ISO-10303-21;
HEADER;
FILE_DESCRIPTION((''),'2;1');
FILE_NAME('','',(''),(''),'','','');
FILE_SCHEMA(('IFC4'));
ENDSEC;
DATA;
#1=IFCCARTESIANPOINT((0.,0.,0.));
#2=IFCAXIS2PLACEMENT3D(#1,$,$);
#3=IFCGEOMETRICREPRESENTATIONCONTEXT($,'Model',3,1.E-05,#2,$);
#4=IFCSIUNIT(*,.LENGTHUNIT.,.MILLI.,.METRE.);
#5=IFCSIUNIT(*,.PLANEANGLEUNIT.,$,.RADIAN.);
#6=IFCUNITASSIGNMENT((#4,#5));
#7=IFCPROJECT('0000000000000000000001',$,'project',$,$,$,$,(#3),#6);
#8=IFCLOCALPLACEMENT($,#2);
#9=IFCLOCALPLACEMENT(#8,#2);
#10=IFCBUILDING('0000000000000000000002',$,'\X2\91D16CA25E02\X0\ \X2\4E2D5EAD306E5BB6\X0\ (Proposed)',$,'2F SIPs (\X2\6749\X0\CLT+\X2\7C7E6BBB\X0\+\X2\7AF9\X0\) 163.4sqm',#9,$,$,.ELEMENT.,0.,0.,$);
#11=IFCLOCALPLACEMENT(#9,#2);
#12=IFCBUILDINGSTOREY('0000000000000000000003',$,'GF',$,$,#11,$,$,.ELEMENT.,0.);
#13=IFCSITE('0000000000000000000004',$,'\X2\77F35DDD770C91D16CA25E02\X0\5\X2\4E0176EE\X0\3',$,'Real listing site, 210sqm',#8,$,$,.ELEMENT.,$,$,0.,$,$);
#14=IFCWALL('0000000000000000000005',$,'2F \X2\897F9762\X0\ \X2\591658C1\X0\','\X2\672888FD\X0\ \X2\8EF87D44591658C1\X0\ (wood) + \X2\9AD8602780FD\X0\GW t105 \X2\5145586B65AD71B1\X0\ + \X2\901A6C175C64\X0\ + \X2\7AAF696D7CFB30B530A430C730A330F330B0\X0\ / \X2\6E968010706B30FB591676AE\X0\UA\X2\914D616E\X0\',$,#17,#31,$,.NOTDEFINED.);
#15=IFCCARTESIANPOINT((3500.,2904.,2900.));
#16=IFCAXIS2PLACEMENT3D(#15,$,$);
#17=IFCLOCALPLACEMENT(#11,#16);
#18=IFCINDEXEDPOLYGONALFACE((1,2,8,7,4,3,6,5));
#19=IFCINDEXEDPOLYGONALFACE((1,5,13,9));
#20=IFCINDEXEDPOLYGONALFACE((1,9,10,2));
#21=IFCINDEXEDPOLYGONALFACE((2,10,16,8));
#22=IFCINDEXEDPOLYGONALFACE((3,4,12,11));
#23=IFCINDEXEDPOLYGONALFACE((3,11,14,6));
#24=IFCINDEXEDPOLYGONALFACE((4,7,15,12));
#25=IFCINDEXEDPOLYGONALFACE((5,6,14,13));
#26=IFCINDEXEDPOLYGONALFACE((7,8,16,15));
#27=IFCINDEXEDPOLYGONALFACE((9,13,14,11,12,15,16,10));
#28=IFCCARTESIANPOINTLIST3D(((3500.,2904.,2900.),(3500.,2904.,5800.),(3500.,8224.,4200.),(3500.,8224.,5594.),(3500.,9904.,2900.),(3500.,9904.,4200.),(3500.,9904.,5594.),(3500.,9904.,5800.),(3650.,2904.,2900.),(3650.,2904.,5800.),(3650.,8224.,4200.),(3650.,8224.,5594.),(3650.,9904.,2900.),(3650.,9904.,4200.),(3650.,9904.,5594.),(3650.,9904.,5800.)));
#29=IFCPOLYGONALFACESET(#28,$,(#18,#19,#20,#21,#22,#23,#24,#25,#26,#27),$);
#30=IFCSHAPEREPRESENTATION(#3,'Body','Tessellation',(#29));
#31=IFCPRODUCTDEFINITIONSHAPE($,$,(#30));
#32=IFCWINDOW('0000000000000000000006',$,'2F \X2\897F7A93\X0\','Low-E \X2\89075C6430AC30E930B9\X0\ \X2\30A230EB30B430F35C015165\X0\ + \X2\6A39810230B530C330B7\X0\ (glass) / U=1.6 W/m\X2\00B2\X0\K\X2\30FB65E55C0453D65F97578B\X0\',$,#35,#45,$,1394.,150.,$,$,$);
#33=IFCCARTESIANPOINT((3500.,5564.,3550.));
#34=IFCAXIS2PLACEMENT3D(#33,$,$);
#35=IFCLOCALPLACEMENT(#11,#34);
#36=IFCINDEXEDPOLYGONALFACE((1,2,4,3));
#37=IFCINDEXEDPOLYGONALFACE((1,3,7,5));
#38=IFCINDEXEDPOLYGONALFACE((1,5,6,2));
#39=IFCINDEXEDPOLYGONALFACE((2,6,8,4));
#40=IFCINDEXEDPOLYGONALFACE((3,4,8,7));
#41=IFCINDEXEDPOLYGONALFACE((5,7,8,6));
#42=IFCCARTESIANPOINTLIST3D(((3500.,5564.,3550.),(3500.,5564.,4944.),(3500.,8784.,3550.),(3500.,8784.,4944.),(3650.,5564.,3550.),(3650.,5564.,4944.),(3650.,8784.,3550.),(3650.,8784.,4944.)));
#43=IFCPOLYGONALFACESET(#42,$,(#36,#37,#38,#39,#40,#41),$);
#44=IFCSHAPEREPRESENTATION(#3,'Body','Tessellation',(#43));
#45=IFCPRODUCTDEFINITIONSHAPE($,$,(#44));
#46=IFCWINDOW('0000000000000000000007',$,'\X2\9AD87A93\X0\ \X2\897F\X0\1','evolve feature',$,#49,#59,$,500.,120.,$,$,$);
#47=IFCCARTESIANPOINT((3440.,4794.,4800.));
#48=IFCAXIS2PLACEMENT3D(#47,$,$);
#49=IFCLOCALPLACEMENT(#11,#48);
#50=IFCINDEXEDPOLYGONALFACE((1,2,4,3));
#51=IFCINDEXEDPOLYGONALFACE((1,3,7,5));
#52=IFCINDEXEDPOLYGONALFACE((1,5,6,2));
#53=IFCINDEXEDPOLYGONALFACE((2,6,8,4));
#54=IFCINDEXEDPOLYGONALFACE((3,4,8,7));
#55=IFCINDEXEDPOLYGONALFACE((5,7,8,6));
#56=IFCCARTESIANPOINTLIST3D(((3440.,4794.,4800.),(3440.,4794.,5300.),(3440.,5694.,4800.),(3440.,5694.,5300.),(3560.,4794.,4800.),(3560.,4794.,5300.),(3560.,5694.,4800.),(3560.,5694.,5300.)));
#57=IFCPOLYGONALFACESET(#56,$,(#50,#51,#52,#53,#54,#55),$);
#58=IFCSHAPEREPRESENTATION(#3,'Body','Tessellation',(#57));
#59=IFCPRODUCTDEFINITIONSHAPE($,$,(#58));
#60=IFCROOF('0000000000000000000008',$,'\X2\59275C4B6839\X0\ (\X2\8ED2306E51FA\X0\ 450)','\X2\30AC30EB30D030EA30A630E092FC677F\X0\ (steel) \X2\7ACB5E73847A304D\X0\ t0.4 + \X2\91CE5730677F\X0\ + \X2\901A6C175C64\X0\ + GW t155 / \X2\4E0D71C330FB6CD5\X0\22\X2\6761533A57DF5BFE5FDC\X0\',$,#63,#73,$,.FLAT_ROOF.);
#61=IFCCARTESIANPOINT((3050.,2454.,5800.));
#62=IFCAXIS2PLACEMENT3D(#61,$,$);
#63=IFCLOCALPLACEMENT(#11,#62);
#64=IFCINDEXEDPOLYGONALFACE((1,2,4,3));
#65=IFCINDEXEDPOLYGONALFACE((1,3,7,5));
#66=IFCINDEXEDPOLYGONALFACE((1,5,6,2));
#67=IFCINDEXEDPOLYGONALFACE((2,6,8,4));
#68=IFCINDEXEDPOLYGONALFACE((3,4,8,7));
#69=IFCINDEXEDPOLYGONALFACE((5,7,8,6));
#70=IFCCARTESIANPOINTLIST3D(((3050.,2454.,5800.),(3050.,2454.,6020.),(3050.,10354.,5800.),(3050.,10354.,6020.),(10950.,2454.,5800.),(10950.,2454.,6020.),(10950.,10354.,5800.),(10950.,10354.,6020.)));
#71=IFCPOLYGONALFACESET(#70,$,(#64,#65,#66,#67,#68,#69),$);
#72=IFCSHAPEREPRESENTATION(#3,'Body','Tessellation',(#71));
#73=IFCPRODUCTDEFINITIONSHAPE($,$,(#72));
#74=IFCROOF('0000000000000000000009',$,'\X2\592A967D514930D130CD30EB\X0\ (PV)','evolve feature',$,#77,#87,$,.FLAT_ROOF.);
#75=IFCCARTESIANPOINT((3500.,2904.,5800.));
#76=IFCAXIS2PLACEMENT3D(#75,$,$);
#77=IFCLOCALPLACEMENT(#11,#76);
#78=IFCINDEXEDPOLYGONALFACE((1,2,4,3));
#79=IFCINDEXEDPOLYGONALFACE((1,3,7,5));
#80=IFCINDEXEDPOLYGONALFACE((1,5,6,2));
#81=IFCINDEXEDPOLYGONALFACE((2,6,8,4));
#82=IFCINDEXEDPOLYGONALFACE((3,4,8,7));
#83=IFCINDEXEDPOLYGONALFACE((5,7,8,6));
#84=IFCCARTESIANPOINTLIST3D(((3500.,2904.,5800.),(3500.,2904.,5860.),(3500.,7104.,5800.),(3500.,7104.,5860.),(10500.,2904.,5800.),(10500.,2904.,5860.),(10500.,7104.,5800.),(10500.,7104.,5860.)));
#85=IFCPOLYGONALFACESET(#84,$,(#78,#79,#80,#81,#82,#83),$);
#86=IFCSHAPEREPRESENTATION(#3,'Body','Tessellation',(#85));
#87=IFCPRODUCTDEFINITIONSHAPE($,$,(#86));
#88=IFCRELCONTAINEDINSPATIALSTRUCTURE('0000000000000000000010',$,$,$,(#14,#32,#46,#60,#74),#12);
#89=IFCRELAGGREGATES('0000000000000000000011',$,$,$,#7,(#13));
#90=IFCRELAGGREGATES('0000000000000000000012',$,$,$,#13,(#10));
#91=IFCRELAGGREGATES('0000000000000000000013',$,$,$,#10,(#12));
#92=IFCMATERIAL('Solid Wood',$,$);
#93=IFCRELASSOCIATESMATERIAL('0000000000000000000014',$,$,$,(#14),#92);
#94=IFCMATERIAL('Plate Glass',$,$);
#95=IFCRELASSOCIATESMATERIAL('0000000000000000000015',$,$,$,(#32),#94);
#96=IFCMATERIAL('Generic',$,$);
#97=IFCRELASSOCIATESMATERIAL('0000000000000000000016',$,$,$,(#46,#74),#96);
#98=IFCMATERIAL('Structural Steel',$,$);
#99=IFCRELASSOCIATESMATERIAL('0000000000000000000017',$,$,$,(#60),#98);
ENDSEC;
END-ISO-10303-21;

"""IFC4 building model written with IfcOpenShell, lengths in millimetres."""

from ifc_helpers import new_model, si_unit, frame, frame_2d, origin, place, context, project, spatial, rectangle, extrude, material, element, fill, save


model = new_model("IFC4")

# Units and contexts
model_context = context("Model", 3, precision=1e-05, world=origin())
ifc_project = project(units=[si_unit("LENGTHUNIT", "METRE", prefix="MILLI"), si_unit("PLANEANGLEUNIT", "RADIAN")], contexts=[model_context])

# Site, building, storey
site_placement = place(None, origin())
site = spatial("IfcSite", under=ifc_project, at=site_placement, Name="石川県金沢市5丁目3", ObjectType="Real listing site, 210sqm", CompositionType="ELEMENT", RefElevation=0.0)
building_placement = place(site_placement, origin())
building = spatial("IfcBuilding", under=site, at=building_placement, Name="金沢市 中庭の家 (Proposed)", ObjectType="2F SIPs (杉CLT+籾殻+竹) 163.4sqm", CompositionType="ELEMENT", ElevationOfRefHeight=0.0, ElevationOfTerrain=0.0)
storey_placement = place(building_placement, origin())
storey = spatial("IfcBuildingStorey", under=building, at=storey_placement, Name="GF", CompositionType="ELEMENT", Elevation=0.0)

# Shared definitions
ifc_material_1 = material(Name="Solid Wood")
ifc_material_2 = material(Name="Generic")

# Shared definitions
ifc_material_3 = material(Name="Plate Glass")

# Wall, openings, windows
wall_1_placement = place(storey_placement, frame((3500.0, 2904.0, 2900.0)))
wall_1 = element("IfcWall", 1, at=wall_1_placement, inside=storey, material=ifc_material_1, Name="2F 西面 外壁", Description="木製 軸組外壁 (wood) + 高性能GW t105 充填断熱 + 通気層 + 窯業系サイディング / 準耐火・外皮UA配慮", PredefinedType="NOTDEFINED", context=model_context, shape_type="SweptSolid", body=[
    extrude(rectangle(XDim=150.0, YDim=7000.0, at=frame_2d((75.0, 3500.0))), frame((3500.0, 2904.0, 2900.0)), (0.0, 0.0, 1.0), 2900.0),
])
opening_1_placement = place(storey_placement, frame((3500.0, 5564.0, 3550.0)))
opening_1 = element("IfcOpeningElement", 2, at=opening_1_placement, cuts=wall_1, PredefinedType="NOTDEFINED", context=model_context, shape_type="SweptSolid", body=[
    extrude(rectangle(XDim=150.0, YDim=3220.0, at=frame_2d((75.0, 1610.0))), frame((3500.0, 5564.0, 3550.0)), (0.0, 0.0, 1.0), 1394.0),
])
opening_2_placement = place(storey_placement, frame((3440.0, 4794.0, 4800.0)))
opening_2 = element("IfcOpeningElement", 3, at=opening_2_placement, cuts=wall_1, PredefinedType="NOTDEFINED", context=model_context, shape_type="SweptSolid", body=[
    extrude(rectangle(XDim=120.0, YDim=900.0, at=frame_2d((60.0, 450.0))), frame((3440.0, 4794.0, 4800.0)), (0.0, 0.0, 1.0), 500.0),
])
window_1_placement = place(storey_placement, frame((3500.0, 5564.0, 3550.0)))
window_1 = element("IfcWindow", 4, at=window_1_placement, inside=storey, material=ifc_material_3, Name="2F 西窓", Description="Low-E 複層ガラス アルゴン封入 + 樹脂サッシ (glass) / U=1.6 W/m²K・日射取得型", OverallHeight=1394.0, OverallWidth=150.0, context=model_context, shape_type="SweptSolid", body=[
    extrude(rectangle(XDim=150.0, YDim=3220.0, at=frame_2d((75.0, 1610.0))), frame((3500.0, 5564.0, 3550.0)), (0.0, 0.0, 1.0), 1394.0),
])
fill(opening_1, window_1)
window_2_placement = place(storey_placement, frame((3440.0, 4794.0, 4800.0)))
window_2 = element("IfcWindow", 5, at=window_2_placement, inside=storey, material=ifc_material_2, Name="高窓 西1", Description="evolve feature", OverallHeight=500.0, OverallWidth=120.0, context=model_context, shape_type="SweptSolid", body=[
    extrude(rectangle(XDim=120.0, YDim=900.0, at=frame_2d((60.0, 450.0))), frame((3440.0, 4794.0, 4800.0)), (0.0, 0.0, 1.0), 500.0),
])
fill(opening_2, window_2)

# Roofs
ifc_material_4 = material(Name="Structural Steel")
roof_1_placement = place(storey_placement, frame((3050.0, 2454.0, 5800.0)))
element("IfcRoof", 6, at=roof_1_placement, inside=storey, material=ifc_material_4, Name="大屋根 (軒の出 450)", Description="ガルバリウム鋼板 (steel) 立平葺き t0.4 + 野地板 + 通気層 + GW t155 / 不燃・法22条区域対応", PredefinedType="FLAT_ROOF", context=model_context, shape_type="SweptSolid", body=[
    extrude(rectangle(XDim=7900.0, YDim=7900.0, at=frame_2d((3950.0, 3950.0))), frame((3050.0, 2454.0, 5800.0)), (0.0, 0.0, 1.0), 220.0),
])
roof_2_placement = place(storey_placement, frame((3500.0, 2904.0, 5800.0)))
element("IfcRoof", 7, at=roof_2_placement, inside=storey, material=ifc_material_2, Name="太陽光パネル (PV)", Description="evolve feature", PredefinedType="FLAT_ROOF", context=model_context, shape_type="SweptSolid", body=[
    extrude(rectangle(XDim=7000.0, YDim=4200.0, at=frame_2d((3500.0, 2100.0))), frame((3500.0, 2904.0, 5800.0)), (0.0, 0.0, 1.0), 60.0),
])

save(model, "model.ifc")
